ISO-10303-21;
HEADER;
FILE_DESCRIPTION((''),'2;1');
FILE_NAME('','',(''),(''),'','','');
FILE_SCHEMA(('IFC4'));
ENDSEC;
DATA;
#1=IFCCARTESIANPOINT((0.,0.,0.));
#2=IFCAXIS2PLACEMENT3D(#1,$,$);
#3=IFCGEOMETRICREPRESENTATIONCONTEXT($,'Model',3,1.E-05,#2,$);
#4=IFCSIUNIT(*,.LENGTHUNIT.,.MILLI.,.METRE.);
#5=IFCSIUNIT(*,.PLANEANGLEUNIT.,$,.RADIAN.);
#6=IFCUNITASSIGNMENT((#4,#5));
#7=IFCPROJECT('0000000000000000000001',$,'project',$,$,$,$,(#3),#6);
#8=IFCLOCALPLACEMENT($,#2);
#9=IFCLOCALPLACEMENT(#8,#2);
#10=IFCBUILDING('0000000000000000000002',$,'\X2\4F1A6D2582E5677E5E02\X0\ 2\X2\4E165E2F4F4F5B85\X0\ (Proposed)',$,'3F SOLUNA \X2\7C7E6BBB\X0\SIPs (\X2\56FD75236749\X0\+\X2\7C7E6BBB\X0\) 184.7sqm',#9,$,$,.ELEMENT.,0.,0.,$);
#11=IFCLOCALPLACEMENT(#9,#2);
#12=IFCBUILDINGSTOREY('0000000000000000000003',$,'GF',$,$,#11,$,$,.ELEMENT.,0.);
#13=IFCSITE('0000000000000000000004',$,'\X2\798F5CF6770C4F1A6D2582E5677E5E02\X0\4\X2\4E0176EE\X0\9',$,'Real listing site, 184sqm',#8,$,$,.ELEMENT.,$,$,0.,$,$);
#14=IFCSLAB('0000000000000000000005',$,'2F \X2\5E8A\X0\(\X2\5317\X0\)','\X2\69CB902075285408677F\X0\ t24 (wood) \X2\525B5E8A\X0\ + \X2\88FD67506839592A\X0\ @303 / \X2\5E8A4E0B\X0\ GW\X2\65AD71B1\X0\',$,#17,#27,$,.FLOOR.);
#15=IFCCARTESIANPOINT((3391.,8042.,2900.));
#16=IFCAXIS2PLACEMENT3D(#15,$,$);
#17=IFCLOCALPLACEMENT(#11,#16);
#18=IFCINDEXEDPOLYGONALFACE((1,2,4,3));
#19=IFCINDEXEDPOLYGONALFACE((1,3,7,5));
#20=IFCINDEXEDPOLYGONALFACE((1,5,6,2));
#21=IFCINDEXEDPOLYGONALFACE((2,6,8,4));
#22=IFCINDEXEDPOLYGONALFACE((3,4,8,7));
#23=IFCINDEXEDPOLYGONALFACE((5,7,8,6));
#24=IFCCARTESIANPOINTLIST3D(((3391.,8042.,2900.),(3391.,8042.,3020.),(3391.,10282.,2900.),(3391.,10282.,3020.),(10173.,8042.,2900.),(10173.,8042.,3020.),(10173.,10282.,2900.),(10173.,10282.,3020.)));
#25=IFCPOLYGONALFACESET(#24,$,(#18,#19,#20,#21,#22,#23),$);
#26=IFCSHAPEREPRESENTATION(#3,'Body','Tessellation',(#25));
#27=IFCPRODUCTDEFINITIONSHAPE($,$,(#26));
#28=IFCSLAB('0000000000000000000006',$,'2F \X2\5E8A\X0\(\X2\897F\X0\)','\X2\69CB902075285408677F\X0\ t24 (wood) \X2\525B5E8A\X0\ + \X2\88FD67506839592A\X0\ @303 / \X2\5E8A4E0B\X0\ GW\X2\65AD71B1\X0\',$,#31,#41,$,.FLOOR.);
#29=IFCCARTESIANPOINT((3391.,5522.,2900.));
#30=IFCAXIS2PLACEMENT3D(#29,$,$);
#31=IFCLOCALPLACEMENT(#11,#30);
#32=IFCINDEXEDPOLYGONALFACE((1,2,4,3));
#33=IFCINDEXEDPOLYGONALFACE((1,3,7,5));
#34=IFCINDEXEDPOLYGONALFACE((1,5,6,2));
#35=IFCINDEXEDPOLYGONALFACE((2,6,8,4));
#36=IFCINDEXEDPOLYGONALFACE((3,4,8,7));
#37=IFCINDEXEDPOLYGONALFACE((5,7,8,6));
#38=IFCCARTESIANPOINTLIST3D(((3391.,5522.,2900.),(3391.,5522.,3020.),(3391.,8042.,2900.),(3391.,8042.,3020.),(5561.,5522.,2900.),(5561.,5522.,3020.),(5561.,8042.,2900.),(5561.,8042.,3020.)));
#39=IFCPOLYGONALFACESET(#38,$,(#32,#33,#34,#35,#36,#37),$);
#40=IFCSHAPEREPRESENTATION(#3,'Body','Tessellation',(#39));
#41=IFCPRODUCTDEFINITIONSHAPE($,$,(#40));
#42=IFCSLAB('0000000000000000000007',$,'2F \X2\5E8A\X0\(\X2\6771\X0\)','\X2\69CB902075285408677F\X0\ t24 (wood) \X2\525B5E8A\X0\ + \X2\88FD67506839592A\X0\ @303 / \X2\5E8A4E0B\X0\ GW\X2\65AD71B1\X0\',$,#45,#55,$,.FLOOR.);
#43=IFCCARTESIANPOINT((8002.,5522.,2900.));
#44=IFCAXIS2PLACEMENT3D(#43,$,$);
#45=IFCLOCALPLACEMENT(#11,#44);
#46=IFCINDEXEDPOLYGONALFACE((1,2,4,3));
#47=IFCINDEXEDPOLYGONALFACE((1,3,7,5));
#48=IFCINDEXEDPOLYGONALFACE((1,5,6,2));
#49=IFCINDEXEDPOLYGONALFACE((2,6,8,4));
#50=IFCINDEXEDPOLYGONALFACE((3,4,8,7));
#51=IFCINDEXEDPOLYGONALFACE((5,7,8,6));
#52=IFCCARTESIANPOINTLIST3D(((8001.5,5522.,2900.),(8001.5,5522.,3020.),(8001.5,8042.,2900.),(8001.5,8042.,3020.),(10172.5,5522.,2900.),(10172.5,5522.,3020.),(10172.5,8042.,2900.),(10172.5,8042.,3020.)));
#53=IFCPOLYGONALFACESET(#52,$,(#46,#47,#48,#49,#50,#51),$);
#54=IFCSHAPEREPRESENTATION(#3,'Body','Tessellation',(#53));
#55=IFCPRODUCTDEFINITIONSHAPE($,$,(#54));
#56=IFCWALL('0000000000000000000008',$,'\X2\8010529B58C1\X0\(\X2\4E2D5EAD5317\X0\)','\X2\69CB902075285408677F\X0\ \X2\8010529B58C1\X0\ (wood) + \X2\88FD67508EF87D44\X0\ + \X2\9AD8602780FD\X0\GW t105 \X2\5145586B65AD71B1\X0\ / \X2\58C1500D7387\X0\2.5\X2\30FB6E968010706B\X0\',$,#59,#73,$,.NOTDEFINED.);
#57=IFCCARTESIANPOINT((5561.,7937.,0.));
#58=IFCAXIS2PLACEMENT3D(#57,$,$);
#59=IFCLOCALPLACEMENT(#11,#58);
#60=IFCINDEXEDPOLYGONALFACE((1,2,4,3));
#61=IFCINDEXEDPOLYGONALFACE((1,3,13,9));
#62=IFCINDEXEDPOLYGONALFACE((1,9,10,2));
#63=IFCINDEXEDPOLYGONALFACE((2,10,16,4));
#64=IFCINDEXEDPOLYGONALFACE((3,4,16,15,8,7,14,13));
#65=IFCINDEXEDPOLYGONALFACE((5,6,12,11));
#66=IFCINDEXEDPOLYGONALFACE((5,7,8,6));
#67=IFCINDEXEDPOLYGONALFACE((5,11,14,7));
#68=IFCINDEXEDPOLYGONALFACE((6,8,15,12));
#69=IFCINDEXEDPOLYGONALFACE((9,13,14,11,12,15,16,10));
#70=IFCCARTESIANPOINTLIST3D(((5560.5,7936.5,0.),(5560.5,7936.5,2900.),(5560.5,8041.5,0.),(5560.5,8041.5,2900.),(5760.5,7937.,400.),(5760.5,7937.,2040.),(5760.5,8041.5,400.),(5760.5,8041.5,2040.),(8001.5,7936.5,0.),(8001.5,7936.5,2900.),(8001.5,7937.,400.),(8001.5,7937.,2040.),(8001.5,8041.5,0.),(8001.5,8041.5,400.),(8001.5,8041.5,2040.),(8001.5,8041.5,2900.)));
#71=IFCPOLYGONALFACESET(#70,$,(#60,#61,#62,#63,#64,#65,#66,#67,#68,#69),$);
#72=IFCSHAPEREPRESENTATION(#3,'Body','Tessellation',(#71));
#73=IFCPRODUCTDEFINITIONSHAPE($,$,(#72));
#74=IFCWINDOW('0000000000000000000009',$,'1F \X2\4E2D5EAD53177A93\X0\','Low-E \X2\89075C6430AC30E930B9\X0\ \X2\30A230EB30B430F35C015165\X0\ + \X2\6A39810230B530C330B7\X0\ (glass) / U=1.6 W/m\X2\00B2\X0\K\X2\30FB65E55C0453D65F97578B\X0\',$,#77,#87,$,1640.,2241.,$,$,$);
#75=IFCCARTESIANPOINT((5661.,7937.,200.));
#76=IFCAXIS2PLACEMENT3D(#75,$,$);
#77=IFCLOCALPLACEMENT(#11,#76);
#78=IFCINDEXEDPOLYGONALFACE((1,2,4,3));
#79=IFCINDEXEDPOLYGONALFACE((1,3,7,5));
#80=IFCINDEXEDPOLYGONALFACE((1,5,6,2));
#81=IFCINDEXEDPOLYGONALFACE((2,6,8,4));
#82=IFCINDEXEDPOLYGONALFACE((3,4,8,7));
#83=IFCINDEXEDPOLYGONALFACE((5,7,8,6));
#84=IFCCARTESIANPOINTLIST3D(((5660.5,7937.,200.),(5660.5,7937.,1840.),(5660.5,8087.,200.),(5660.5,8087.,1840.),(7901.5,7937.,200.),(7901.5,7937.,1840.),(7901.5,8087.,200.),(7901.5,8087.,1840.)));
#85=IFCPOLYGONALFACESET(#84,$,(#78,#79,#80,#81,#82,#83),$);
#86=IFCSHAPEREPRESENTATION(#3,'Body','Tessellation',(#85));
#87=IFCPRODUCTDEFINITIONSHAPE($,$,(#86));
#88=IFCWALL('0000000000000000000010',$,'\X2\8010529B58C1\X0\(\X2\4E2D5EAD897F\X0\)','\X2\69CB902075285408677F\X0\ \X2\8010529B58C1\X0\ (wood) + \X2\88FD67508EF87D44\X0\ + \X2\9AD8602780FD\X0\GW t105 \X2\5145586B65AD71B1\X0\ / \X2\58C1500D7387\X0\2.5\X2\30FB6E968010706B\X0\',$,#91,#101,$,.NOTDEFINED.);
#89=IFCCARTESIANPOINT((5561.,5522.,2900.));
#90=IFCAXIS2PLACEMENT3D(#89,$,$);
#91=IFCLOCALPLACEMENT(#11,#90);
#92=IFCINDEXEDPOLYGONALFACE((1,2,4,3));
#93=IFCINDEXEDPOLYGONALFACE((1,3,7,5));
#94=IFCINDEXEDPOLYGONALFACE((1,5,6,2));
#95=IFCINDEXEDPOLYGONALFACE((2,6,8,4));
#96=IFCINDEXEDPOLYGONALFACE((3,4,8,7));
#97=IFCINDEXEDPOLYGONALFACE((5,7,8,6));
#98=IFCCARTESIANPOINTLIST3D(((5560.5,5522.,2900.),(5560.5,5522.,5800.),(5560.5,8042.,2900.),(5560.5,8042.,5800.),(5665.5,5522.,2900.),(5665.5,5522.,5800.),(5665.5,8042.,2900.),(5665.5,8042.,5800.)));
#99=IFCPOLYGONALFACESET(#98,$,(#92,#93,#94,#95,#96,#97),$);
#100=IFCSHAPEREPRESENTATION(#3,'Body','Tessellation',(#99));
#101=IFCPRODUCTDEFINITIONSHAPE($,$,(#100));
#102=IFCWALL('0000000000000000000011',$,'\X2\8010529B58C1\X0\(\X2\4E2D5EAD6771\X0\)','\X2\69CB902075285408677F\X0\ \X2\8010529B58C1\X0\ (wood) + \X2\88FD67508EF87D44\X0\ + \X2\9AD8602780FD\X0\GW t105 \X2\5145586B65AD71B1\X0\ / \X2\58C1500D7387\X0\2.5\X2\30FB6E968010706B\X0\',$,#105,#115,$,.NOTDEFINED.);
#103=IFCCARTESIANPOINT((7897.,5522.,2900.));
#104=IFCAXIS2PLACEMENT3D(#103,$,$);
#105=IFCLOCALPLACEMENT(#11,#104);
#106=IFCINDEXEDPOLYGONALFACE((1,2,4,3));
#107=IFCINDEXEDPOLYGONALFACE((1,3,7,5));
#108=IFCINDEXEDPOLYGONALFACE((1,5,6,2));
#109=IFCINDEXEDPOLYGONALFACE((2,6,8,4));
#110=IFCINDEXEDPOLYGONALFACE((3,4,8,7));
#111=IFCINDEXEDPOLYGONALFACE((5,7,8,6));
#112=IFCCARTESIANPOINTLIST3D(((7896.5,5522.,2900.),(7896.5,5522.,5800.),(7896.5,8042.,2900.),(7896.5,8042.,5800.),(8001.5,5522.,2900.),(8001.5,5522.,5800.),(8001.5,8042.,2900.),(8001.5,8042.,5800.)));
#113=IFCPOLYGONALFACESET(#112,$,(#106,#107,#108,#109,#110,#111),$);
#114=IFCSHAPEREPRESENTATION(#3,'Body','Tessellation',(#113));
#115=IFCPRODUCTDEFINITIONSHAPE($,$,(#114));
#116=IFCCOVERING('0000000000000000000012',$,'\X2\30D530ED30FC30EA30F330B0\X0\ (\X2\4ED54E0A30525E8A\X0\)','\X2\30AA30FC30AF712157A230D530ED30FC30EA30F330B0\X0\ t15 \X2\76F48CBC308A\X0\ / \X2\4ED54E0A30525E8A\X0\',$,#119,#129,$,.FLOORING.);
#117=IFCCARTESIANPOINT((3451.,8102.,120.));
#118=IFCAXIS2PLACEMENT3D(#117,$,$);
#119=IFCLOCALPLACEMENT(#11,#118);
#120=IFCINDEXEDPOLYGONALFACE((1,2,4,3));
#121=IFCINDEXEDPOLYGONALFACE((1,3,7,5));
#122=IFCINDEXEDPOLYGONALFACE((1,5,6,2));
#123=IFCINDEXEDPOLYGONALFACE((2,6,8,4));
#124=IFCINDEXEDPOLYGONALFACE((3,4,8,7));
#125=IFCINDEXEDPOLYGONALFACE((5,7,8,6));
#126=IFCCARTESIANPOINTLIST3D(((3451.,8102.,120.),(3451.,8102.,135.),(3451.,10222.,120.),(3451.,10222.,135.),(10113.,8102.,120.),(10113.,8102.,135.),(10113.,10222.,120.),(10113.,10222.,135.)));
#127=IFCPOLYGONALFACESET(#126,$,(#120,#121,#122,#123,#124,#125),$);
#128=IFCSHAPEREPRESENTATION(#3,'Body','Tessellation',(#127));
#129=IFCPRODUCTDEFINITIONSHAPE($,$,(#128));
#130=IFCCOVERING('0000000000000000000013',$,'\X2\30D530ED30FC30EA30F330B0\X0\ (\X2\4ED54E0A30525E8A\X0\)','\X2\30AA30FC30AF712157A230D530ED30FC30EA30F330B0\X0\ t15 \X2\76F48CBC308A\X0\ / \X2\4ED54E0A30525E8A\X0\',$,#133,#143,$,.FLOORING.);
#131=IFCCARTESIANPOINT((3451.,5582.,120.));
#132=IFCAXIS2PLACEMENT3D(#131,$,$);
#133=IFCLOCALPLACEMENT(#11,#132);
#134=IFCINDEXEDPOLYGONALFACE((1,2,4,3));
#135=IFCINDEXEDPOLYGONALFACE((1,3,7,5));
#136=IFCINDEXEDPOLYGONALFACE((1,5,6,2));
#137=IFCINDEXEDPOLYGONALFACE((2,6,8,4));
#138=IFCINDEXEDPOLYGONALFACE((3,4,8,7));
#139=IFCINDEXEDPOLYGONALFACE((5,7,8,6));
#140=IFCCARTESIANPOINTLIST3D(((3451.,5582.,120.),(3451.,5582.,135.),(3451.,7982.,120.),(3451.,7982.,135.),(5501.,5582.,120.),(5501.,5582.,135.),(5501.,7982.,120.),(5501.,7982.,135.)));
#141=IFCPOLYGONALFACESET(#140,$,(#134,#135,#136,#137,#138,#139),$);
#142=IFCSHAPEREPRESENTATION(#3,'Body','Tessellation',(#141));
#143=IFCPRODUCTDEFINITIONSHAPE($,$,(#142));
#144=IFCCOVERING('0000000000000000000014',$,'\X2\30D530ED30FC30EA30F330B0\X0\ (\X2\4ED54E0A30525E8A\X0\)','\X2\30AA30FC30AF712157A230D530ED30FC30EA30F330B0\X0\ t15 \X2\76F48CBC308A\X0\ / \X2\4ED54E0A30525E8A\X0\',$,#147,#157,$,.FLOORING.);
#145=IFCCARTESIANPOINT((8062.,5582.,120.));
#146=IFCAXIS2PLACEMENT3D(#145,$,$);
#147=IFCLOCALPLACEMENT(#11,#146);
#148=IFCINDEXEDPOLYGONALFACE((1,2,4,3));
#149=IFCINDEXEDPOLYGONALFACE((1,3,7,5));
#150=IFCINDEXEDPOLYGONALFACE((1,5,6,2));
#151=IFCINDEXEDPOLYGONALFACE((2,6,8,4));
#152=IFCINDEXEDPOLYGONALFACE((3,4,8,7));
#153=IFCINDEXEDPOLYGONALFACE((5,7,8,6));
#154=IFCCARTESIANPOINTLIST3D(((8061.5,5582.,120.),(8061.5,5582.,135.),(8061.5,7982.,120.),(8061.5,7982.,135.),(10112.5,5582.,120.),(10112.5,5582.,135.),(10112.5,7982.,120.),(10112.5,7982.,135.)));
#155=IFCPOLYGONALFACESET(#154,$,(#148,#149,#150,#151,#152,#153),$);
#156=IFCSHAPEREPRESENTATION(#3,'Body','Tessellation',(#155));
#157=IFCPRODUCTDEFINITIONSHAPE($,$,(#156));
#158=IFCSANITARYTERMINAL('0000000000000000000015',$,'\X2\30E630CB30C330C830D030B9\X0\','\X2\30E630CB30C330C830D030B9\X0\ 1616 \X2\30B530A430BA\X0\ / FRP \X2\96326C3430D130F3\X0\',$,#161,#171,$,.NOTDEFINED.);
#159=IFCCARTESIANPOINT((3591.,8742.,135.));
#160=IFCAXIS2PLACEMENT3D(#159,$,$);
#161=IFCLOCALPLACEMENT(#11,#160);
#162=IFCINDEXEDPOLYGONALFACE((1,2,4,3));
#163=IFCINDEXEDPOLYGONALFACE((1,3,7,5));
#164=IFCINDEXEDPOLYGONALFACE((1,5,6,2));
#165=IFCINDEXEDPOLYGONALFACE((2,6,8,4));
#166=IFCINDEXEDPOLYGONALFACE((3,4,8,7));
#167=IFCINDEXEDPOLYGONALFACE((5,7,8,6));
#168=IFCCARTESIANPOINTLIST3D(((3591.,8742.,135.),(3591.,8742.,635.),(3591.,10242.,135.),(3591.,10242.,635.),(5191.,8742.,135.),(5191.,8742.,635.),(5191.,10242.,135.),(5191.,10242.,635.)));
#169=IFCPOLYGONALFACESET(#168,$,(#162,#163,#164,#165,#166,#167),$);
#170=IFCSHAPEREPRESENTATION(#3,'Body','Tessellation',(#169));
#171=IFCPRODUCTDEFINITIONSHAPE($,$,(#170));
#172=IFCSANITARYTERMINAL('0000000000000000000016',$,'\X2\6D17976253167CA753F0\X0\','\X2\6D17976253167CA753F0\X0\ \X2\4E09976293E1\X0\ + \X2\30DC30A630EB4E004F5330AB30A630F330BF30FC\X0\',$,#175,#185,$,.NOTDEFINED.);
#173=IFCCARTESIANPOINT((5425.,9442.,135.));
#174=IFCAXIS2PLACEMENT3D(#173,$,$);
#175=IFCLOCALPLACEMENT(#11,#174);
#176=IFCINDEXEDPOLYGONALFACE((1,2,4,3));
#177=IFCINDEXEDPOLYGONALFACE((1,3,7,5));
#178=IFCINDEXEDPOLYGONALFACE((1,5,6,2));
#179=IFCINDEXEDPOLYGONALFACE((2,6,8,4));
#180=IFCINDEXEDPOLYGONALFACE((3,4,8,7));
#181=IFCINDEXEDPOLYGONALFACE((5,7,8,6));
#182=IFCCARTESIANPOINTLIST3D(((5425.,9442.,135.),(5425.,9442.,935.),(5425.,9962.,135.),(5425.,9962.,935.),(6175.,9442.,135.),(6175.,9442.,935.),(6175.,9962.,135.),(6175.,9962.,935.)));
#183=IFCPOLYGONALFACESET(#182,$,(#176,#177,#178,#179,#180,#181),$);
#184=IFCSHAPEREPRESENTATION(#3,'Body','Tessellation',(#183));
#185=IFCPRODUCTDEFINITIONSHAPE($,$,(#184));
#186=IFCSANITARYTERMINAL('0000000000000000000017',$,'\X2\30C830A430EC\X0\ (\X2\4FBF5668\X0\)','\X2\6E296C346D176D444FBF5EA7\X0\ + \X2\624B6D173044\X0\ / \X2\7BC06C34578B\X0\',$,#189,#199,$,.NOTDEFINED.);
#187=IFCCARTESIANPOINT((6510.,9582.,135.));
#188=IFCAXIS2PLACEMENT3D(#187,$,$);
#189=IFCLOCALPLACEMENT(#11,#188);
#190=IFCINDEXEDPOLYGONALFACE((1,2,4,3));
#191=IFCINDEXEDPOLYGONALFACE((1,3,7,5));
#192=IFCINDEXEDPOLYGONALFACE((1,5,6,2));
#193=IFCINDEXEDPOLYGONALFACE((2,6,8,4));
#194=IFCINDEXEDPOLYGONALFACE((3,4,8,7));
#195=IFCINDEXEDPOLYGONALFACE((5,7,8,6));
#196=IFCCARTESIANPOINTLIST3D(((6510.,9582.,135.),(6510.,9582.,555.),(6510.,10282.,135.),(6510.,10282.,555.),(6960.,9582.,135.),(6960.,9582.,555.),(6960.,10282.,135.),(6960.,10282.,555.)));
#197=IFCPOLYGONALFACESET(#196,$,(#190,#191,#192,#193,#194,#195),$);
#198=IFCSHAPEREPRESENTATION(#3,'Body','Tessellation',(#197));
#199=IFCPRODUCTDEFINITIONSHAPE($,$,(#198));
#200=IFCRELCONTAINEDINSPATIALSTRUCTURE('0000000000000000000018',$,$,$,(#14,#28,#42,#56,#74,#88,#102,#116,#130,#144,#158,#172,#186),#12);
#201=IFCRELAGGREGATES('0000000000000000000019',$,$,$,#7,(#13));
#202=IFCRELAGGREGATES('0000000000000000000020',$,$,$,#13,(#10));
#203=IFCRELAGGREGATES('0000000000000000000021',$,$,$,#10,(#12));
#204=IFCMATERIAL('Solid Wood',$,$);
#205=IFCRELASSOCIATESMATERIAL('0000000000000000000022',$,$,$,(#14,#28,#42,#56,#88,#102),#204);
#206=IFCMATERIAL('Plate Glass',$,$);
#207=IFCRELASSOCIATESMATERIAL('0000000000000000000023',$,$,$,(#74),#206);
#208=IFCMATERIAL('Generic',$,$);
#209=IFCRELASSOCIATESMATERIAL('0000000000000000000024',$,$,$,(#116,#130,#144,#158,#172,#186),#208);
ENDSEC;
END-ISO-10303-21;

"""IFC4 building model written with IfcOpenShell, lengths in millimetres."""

from ifc_helpers import new_model, si_unit, frame, frame_2d, origin, place, context, project, spatial, rectangle, extrude, material, element, fill, save


model = new_model("IFC4")

# Units and contexts
model_context = context("Model", 3, precision=1e-05, world=origin())
ifc_project = project(units=[si_unit("LENGTHUNIT", "METRE", prefix="MILLI"), si_unit("PLANEANGLEUNIT", "RADIAN")], contexts=[model_context])

# Site, building, storey
site_placement = place(None, origin())
site = spatial("IfcSite", under=ifc_project, at=site_placement, Name="福島県会津若松市4丁目9", ObjectType="Real listing site, 184sqm", CompositionType="ELEMENT", RefElevation=0.0)
building_placement = place(site_placement, origin())
building = spatial("IfcBuilding", under=site, at=building_placement, Name="会津若松市 2世帯住宅 (Proposed)", ObjectType="3F SOLUNA 籾殻SIPs (国産杉+籾殻) 184.7sqm", CompositionType="ELEMENT", ElevationOfRefHeight=0.0, ElevationOfTerrain=0.0)
storey_placement = place(building_placement, origin())
storey = spatial("IfcBuildingStorey", under=building, at=storey_placement, Name="GF", CompositionType="ELEMENT", Elevation=0.0)

# Slabs
ifc_material_1 = material(Name="Solid Wood")
slab_1_placement = place(storey_placement, frame((3391.0, 8042.0, 2900.0)))
element("IfcSlab", 1, at=slab_1_placement, inside=storey, material=ifc_material_1, Name="2F 床(北)", Description="構造用合板 t24 (wood) 剛床 + 製材根太 @303 / 床下 GW断熱", PredefinedType="FLOOR", context=model_context, shape_type="SweptSolid", body=[
    extrude(rectangle(XDim=6782.0, YDim=2240.0, at=frame_2d((3391.0, 1120.0))), frame((3391.0, 8042.0, 2900.0)), (0.0, 0.0, 1.0), 120.0),
])
slab_2_placement = place(storey_placement, frame((3391.0, 5522.0, 2900.0)))
element("IfcSlab", 2, at=slab_2_placement, inside=storey, material=ifc_material_1, Name="2F 床(西)", Description="構造用合板 t24 (wood) 剛床 + 製材根太 @303 / 床下 GW断熱", PredefinedType="FLOOR", context=model_context, shape_type="SweptSolid", body=[
    extrude(rectangle(XDim=2170.0, YDim=2520.0, at=frame_2d((1085.0, 1260.0))), frame((3391.0, 5522.0, 2900.0)), (0.0, 0.0, 1.0), 120.0),
])
slab_3_placement = place(storey_placement, frame((8002.0, 5522.0, 2900.0)))
element("IfcSlab", 3, at=slab_3_placement, inside=storey, material=ifc_material_1, Name="2F 床(東)", Description="構造用合板 t24 (wood) 剛床 + 製材根太 @303 / 床下 GW断熱", PredefinedType="FLOOR", context=model_context, shape_type="SweptSolid", body=[
    extrude(rectangle(XDim=2171.0, YDim=2520.0, at=frame_2d((1085.0, 1260.0))), frame((8002.0, 5522.0, 2900.0)), (0.0, 0.0, 1.0), 120.0),
])

# Wall, opening, window
wall_1_placement = place(storey_placement, frame((5561.0, 7937.0, 0.0)))
wall_1 = element("IfcWall", 4, at=wall_1_placement, inside=storey, material=ifc_material_1, Name="耐力壁(中庭北)", Description="構造用合板 耐力壁 (wood) + 製材軸組 + 高性能GW t105 充填断熱 / 壁倍率2.5・準耐火", PredefinedType="NOTDEFINED", context=model_context, shape_type="SweptSolid", body=[
    extrude(rectangle(XDim=2441.0, YDim=105.0, at=frame_2d((1220.0, 52.0))), frame((5561.0, 7937.0, 0.0)), (0.0, 0.0, 1.0), 2900.0),
])
opening_1_placement = place(storey_placement, frame((5661.0, 7937.0, 200.0)))
opening_1 = element("IfcOpeningElement", 5, at=opening_1_placement, cuts=wall_1, PredefinedType="NOTDEFINED", context=model_context, shape_type="SweptSolid", body=[
    extrude(rectangle(XDim=2241.0, YDim=150.0, at=frame_2d((1120.0, 75.0))), frame((5661.0, 7937.0, 200.0)), (0.0, 0.0, 1.0), 1640.0),
])
ifc_material_2 = material(Name="Plate Glass")
window_1_placement = place(storey_placement, frame((5661.0, 7937.0, 200.0)))
window_1 = element("IfcWindow", 6, at=window_1_placement, inside=storey, material=ifc_material_2, Name="1F 中庭北窓", Description="Low-E 複層ガラス アルゴン封入 + 樹脂サッシ (glass) / U=1.6 W/m²K・日射取得型", OverallHeight=1640.0, OverallWidth=2241.0, context=model_context, shape_type="SweptSolid", body=[
    extrude(rectangle(XDim=2241.0, YDim=150.0, at=frame_2d((1120.0, 75.0))), frame((5661.0, 7937.0, 200.0)), (0.0, 0.0, 1.0), 1640.0),
])
fill(opening_1, window_1)

# Walls
wall_2_placement = place(storey_placement, frame((5561.0, 5522.0, 2900.0)))
element("IfcWall", 7, at=wall_2_placement, inside=storey, material=ifc_material_1, Name="耐力壁(中庭西)", Description="構造用合板 耐力壁 (wood) + 製材軸組 + 高性能GW t105 充填断熱 / 壁倍率2.5・準耐火", PredefinedType="NOTDEFINED", context=model_context, shape_type="SweptSolid", body=[
    extrude(rectangle(XDim=105.0, YDim=2520.0, at=frame_2d((52.0, 1260.0))), frame((5561.0, 5522.0, 2900.0)), (0.0, 0.0, 1.0), 2900.0),
])
wall_3_placement = place(storey_placement, frame((7897.0, 5522.0, 2900.0)))
element("IfcWall", 8, at=wall_3_placement, inside=storey, material=ifc_material_1, Name="耐力壁(中庭東)", Description="構造用合板 耐力壁 (wood) + 製材軸組 + 高性能GW t105 充填断熱 / 壁倍率2.5・準耐火", PredefinedType="NOTDEFINED", context=model_context, shape_type="SweptSolid", body=[
    extrude(rectangle(XDim=105.0, YDim=2520.0, at=frame_2d((52.0, 1260.0))), frame((7897.0, 5522.0, 2900.0)), (0.0, 0.0, 1.0), 2900.0),
])

# Coverings
ifc_material_3 = material(Name="Generic")
covering_1_placement = place(storey_placement, frame((3451.0, 8102.0, 120.0)))
element("IfcCovering", 9, at=covering_1_placement, inside=storey, material=ifc_material_3, Name="フローリング (仕上げ床)", Description="オーク無垢フローリング t15 直貼り / 仕上げ床", PredefinedType="FLOORING", context=model_context, shape_type="SweptSolid", body=[
    extrude(rectangle(XDim=6662.0, YDim=2120.0, at=frame_2d((3331.0, 1060.0))), frame((3451.0, 8102.0, 120.0)), (0.0, 0.0, 1.0), 15.0),
])
covering_2_placement = place(storey_placement, frame((3451.0, 5582.0, 120.0)))
element("IfcCovering", 10, at=covering_2_placement, inside=storey, material=ifc_material_3, Name="フローリング (仕上げ床)", Description="オーク無垢フローリング t15 直貼り / 仕上げ床", PredefinedType="FLOORING", context=model_context, shape_type="SweptSolid", body=[
    extrude(rectangle(XDim=2050.0, YDim=2400.0, at=frame_2d((1025.0, 1200.0))), frame((3451.0, 5582.0, 120.0)), (0.0, 0.0, 1.0), 15.0),
])
covering_3_placement = place(storey_placement, frame((8062.0, 5582.0, 120.0)))
element("IfcCovering", 11, at=covering_3_placement, inside=storey, material=ifc_material_3, Name="フローリング (仕上げ床)", Description="オーク無垢フローリング t15 直貼り / 仕上げ床", PredefinedType="FLOORING", context=model_context, shape_type="SweptSolid", body=[
    extrude(rectangle(XDim=2051.0, YDim=2400.0, at=frame_2d((1025.0, 1200.0))), frame((8062.0, 5582.0, 120.0)), (0.0, 0.0, 1.0), 15.0),
])

# Sanitary terminals
sanitary_terminal_1_placement = place(storey_placement, frame((3591.0, 8742.0, 135.0)))
element("IfcSanitaryTerminal", 12, at=sanitary_terminal_1_placement, inside=storey, material=ifc_material_3, Name="ユニットバス", Description="ユニットバス 1616 サイズ / FRP 防水パン", PredefinedType="NOTDEFINED", context=model_context, shape_type="SweptSolid", body=[
    extrude(rectangle(XDim=1600.0, YDim=1500.0, at=frame_2d((800.0, 750.0))), frame((3591.0, 8742.0, 135.0)), (0.0, 0.0, 1.0), 500.0),
])
sanitary_terminal_2_placement = place(storey_placement, frame((5425.0, 9442.0, 135.0)))
element("IfcSanitaryTerminal", 13, at=sanitary_terminal_2_placement, inside=storey, material=ifc_material_3, Name="洗面化粧台", Description="洗面化粧台 三面鏡 + ボウル一体カウンター", PredefinedType="NOTDEFINED", context=model_context, shape_type="SweptSolid", body=[
    extrude(rectangle(XDim=750.0, YDim=520.0, at=frame_2d((375.0, 260.0))), frame((5425.0, 9442.0, 135.0)), (0.0, 0.0, 1.0), 800.0),
])
sanitary_terminal_3_placement = place(storey_placement, frame((6510.0, 9582.0, 135.0)))
element("IfcSanitaryTerminal", 14, at=sanitary_terminal_3_placement, inside=storey, material=ifc_material_3, Name="トイレ (便器)", Description="温水洗浄便座 + 手洗い / 節水型", PredefinedType="NOTDEFINED", context=model_context, shape_type="SweptSolid", body=[
    extrude(rectangle(XDim=450.0, YDim=700.0, at=frame_2d((225.0, 350.0))), frame((6510.0, 9582.0, 135.0)), (0.0, 0.0, 1.0), 420.0),
])

save(model, "model.ifc")
